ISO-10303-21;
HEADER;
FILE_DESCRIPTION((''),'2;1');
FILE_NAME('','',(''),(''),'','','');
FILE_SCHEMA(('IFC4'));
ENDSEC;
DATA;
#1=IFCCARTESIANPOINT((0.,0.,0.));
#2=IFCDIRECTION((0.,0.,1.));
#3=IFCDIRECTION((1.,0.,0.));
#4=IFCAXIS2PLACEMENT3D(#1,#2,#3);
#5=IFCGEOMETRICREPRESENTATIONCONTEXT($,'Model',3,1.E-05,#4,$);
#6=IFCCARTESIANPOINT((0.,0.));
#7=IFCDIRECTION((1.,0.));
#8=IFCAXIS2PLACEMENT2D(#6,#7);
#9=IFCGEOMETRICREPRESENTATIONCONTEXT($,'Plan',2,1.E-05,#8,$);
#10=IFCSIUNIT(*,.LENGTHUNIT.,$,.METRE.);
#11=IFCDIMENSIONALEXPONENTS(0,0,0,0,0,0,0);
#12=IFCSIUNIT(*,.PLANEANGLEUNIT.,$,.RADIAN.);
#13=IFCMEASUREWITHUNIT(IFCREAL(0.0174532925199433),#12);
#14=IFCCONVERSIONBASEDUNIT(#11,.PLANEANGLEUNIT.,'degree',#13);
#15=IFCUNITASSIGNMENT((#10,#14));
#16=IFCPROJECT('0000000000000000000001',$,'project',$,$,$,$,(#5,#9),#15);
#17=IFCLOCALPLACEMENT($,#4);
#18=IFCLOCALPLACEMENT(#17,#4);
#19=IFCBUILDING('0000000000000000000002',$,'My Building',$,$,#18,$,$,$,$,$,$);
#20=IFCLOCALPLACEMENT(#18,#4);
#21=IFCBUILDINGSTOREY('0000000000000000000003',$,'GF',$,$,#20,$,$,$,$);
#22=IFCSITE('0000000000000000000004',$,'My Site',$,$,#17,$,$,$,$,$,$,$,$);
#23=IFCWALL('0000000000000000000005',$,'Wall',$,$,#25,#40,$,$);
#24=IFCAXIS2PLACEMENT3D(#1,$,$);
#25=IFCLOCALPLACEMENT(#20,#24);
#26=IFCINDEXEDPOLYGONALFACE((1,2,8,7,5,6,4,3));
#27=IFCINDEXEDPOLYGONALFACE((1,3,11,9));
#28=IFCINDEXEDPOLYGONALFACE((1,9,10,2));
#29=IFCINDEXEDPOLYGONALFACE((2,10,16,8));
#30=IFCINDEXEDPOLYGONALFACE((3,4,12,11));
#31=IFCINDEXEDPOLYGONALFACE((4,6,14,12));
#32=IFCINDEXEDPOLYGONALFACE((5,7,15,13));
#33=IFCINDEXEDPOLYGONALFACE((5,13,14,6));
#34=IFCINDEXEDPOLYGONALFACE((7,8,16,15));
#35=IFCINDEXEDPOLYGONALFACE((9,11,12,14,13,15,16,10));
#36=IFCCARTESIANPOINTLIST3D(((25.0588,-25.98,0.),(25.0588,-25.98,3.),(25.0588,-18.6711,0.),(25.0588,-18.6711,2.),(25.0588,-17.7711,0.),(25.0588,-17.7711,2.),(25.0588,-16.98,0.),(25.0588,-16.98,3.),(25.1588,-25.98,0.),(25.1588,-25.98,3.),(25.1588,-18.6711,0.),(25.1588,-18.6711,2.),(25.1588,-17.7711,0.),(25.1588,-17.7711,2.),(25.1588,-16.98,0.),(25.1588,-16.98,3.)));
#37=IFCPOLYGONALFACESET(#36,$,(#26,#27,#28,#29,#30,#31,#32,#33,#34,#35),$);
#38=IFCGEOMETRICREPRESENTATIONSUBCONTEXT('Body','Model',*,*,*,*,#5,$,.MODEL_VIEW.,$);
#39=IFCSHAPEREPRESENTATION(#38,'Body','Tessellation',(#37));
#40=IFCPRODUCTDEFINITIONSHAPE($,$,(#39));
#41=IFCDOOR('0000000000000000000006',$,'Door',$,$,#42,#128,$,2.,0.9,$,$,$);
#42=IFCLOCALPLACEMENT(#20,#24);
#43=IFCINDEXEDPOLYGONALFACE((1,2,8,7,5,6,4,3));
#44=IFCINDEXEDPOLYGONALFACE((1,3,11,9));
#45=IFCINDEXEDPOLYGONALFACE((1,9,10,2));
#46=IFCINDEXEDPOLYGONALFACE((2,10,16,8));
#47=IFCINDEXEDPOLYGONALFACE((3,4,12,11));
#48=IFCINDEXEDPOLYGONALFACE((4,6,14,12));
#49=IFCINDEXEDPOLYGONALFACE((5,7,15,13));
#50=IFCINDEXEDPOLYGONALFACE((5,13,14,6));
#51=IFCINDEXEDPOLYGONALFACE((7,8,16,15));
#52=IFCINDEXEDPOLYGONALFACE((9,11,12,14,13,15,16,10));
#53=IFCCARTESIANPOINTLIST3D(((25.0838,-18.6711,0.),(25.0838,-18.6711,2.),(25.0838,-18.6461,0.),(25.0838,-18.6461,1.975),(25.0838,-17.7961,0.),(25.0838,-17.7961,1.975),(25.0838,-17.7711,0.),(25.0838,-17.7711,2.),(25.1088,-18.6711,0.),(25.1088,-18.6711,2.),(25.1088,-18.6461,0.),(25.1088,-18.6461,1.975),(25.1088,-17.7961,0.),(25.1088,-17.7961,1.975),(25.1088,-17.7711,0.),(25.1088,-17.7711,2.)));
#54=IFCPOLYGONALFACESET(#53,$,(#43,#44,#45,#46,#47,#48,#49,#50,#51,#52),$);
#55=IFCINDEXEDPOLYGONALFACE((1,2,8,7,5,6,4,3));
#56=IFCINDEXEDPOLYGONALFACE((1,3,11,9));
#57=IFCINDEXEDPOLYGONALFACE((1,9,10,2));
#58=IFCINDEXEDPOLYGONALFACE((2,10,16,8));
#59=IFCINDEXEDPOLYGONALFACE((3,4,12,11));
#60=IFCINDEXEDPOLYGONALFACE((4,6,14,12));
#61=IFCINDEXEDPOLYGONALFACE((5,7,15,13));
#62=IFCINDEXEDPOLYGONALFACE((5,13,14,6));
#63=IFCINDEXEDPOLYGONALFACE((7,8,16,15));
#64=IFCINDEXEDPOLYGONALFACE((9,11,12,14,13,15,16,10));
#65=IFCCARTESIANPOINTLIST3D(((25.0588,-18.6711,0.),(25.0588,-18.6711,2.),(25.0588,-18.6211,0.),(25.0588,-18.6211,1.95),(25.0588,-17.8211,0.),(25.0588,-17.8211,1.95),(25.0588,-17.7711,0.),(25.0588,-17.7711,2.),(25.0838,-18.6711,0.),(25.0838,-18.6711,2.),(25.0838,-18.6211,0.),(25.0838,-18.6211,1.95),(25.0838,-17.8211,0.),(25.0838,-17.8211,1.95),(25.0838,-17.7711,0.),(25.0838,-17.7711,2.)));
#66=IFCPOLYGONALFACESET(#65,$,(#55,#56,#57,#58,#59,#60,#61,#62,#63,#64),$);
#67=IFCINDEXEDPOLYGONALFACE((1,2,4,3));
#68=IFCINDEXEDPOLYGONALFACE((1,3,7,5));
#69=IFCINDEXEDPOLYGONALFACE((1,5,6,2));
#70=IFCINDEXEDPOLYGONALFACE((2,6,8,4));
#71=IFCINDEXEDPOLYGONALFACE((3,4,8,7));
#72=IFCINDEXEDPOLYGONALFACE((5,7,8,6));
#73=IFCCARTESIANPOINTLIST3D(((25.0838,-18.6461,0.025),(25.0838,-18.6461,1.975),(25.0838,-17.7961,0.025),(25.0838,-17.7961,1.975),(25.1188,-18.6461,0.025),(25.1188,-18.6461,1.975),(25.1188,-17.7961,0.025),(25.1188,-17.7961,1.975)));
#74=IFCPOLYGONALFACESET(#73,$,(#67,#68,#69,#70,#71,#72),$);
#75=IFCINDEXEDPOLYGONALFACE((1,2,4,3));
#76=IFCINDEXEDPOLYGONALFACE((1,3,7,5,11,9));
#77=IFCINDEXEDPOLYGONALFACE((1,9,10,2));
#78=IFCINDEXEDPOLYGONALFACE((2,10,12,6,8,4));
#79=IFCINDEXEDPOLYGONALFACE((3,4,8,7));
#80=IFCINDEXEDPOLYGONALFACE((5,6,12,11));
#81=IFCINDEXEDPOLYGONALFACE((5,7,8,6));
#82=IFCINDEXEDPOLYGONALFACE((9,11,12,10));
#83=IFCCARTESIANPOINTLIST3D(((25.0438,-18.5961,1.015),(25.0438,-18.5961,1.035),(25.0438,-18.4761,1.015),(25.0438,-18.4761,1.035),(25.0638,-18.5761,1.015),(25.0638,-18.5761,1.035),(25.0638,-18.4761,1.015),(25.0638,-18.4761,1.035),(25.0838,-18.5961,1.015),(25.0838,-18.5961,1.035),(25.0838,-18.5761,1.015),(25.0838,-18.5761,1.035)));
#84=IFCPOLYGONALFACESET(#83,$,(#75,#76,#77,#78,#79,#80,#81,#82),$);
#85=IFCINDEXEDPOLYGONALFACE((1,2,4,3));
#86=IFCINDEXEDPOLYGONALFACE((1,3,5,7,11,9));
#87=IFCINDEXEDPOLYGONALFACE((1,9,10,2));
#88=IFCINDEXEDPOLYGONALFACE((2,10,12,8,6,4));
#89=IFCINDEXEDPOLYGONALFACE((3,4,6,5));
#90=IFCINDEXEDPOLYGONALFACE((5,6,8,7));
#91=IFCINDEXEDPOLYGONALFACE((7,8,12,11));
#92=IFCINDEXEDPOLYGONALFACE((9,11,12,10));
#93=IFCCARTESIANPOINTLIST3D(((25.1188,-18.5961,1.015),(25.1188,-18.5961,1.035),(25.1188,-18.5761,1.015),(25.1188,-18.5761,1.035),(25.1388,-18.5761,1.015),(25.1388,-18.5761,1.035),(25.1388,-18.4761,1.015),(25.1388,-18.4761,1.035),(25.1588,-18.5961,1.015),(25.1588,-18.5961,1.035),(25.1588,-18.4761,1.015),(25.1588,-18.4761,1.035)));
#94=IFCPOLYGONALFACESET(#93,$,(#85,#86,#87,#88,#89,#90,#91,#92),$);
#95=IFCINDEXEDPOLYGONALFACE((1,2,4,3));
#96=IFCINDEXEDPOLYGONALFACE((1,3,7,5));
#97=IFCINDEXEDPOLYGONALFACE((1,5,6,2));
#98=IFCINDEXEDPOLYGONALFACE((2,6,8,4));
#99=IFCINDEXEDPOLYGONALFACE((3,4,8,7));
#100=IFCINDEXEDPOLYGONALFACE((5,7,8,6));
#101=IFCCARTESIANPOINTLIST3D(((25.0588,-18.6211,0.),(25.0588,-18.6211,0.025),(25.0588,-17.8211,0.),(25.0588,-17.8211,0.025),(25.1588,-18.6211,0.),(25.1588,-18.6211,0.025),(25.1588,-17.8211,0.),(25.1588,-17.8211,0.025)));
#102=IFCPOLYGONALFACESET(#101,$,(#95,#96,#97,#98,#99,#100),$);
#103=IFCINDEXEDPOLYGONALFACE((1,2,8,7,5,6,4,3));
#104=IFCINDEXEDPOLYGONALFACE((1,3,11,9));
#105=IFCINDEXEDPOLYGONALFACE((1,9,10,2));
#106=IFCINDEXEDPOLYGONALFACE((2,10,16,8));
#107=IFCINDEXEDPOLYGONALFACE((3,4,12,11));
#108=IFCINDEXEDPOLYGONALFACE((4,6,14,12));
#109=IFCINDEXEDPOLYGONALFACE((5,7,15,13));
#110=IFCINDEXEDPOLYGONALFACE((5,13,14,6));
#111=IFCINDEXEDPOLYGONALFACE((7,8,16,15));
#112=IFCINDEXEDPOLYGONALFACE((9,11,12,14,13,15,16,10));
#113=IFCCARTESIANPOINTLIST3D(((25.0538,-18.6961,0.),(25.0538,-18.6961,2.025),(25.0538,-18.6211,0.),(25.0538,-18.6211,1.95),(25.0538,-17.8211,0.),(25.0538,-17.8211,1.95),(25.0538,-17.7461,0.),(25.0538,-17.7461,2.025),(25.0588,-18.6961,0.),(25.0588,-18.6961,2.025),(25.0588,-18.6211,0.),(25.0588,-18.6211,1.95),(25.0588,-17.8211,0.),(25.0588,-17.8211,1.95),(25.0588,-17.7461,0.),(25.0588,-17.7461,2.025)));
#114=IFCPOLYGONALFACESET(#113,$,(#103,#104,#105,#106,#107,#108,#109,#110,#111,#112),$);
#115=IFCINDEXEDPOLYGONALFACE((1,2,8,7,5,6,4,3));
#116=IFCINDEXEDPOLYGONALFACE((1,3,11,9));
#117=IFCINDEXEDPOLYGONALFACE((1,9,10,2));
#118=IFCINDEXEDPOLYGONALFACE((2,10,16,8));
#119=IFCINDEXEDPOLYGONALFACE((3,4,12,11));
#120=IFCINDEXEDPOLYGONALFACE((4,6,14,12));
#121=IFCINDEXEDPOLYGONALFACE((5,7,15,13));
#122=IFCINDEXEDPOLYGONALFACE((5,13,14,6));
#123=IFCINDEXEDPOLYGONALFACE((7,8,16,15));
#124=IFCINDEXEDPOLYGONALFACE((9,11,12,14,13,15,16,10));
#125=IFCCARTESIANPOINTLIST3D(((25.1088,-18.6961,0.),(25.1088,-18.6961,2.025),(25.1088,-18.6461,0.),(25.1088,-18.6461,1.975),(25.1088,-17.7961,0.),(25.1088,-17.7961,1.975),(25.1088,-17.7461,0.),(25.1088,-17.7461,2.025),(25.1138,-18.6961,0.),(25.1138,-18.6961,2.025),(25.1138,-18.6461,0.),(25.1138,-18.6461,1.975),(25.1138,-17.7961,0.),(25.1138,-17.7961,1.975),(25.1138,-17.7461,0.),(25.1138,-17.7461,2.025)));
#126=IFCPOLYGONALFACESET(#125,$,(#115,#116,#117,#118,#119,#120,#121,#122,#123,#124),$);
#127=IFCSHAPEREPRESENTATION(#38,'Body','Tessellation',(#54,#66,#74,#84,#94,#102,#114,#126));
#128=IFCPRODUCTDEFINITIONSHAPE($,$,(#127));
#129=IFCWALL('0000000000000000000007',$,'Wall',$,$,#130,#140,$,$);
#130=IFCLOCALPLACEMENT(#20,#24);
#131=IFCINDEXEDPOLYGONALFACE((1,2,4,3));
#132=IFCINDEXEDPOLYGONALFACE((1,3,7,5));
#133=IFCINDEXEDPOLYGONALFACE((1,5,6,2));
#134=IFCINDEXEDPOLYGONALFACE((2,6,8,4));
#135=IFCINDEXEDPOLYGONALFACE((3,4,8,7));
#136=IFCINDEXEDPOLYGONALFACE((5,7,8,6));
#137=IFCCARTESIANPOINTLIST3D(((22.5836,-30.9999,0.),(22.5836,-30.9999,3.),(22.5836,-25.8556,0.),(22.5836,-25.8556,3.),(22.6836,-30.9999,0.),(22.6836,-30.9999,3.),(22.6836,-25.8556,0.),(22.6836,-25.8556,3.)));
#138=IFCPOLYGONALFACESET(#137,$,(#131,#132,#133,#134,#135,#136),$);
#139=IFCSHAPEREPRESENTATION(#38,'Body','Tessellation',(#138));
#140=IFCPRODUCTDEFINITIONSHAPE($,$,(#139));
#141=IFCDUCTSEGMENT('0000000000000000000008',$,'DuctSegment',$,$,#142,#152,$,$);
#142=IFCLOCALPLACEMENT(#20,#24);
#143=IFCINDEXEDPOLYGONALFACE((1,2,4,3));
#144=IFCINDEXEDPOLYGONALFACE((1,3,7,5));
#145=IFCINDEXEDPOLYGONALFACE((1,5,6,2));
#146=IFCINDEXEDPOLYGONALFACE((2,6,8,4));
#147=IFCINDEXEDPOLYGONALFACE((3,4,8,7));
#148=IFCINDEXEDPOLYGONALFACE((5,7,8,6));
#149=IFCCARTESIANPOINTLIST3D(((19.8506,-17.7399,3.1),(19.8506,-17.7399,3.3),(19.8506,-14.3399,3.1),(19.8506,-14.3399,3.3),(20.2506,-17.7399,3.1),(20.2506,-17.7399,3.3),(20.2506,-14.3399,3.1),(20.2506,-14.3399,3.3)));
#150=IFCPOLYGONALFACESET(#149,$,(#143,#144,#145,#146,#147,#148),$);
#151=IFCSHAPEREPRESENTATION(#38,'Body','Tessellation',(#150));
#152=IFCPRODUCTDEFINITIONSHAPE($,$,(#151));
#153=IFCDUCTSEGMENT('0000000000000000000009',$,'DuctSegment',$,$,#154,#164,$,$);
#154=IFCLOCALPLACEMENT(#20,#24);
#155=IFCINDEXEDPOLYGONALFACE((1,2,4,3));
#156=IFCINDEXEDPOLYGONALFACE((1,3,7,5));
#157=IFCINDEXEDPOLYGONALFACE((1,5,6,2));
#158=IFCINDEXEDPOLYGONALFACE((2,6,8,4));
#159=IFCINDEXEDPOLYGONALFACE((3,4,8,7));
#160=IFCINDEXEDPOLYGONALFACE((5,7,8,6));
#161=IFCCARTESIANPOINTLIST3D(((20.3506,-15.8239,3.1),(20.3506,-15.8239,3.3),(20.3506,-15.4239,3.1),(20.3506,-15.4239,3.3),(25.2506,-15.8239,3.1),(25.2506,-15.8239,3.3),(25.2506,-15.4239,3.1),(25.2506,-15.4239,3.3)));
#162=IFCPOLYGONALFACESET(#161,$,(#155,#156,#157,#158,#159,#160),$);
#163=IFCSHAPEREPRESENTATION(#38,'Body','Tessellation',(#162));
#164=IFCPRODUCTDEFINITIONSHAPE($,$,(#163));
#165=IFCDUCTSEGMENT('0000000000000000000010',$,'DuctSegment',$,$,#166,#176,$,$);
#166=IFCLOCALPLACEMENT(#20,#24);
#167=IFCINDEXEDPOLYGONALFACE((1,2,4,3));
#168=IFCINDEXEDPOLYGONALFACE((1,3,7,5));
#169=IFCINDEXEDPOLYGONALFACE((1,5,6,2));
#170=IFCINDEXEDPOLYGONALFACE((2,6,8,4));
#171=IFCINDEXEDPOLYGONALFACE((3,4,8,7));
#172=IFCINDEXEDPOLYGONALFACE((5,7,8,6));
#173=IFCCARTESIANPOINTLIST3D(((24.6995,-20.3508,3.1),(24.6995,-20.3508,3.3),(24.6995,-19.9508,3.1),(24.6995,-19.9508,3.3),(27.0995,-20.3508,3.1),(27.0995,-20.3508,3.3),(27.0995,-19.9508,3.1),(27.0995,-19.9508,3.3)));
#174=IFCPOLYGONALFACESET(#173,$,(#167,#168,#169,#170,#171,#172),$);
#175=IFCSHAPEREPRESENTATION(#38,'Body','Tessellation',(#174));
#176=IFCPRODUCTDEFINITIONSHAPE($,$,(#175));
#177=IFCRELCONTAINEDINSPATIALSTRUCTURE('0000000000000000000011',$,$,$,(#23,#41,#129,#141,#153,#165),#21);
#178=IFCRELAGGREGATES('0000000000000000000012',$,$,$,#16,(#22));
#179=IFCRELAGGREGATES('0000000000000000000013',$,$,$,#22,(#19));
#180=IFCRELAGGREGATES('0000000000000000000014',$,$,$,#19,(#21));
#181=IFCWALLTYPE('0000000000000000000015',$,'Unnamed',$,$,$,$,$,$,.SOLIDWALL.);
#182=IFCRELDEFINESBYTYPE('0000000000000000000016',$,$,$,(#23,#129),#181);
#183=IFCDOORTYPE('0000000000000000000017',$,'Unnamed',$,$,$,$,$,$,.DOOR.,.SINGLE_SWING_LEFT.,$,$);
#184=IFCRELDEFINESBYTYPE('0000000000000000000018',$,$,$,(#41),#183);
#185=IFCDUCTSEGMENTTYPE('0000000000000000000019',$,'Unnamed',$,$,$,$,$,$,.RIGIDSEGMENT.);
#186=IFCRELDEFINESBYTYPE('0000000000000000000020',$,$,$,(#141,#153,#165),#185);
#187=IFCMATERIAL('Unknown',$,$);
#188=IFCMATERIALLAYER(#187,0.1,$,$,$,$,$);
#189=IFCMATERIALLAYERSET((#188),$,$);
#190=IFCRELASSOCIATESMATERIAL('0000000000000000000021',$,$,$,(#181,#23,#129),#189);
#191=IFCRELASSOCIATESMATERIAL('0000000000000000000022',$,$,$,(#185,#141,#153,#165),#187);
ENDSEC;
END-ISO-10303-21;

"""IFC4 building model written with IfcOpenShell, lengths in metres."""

from ifc_helpers import new_model, entity, si_unit, converted_unit, frame, origin_with_axes, origin_2d_with_axis, place, context, subcontext, project, spatial, line, indexed_curve, rectangle, outline, extrude, shape, source, transform, mapped, material, layer, layer_set, layer_usage, material_profile, profile_set, profile_usage, type_object, type_shapes, element, fill, save


model = new_model("IFC4")

# Units and contexts
model_context = context("Model", 3, precision=1e-05, world=origin_with_axes())
plan_context = context("Plan", 2, precision=1e-05, world=origin_2d_with_axis())
body_context_1 = subcontext(model_context, "Body", "Model", "MODEL_VIEW")
body_context_2 = subcontext(plan_context, "Body", "Plan", "PLAN_VIEW")
ifc_project = project(units=[si_unit("LENGTHUNIT", "METRE"), converted_unit("PLANEANGLEUNIT", "degree", entity("IfcReal", 0.0174532925199433), si_unit("PLANEANGLEUNIT", "RADIAN"), dimensions=[0, 0, 0, 0, 0, 0, 0])], contexts=[model_context, plan_context])

# Site, building, storey
site_placement = place(None, origin_with_axes())
site = spatial("IfcSite", under=ifc_project, at=site_placement, Name="My Site")
building_placement = place(site_placement, origin_with_axes())
building = spatial("IfcBuilding", under=site, at=building_placement, Name="My Building")
storey_placement = place(building_placement, origin_with_axes())
storey = spatial("IfcBuildingStorey", under=building, at=storey_placement, Name="GF")

# Shared definitions
ifc_material = material(Name="Unknown")
ifc_layer = layer(ifc_material, 0.1)
ifc_layer_set = layer_set([ifc_layer])
wall_type = type_object("IfcWallType", Name="Unnamed", PredefinedType="SOLIDWALL", material=ifc_layer_set)

# Shared definitions
shared_shape_1 = source(origin_with_axes(), body_context_1, "Body", "SweptSolid", [
    extrude(outline(indexed_curve([(0.0, 0.0), (0.9, 0.0), (0.9, 2.0), (0.0, 2.0)], segments=[line(1, 2, 3, 4, 1)])), frame((0.0, -0.6, 0.0), z_axis=(0.0, -1.0, 0.0), x_axis=(1.0, 0.0, 0.0)), (0.0, 0.0, -1.0), 1.2),
])
door_type = type_object("IfcDoorType", Name="Unnamed", OperationType="SINGLE_SWING_LEFT", PredefinedType="DOOR")
shared_shape_2 = source(origin_with_axes(), body_context_1, "Body", "SweptSolid", [
    extrude(outline(indexed_curve([(0.0, 0.0), (0.0, 2.0), (0.9, 2.0), (0.9, 0.0), (0.875, 0.0), (0.875, 1.975), (0.025, 1.975), (0.025, 0.0)], segments=[line(1, 2, 3, 4, 5, 6, 7, 8, 1)])), frame((0.0, 0.025, 0.0), z_axis=(0.0, -1.0, 0.0), x_axis=(1.0, 0.0, 0.0)), (0.0, 0.0, -1.0), 0.025),
    extrude(outline(indexed_curve([(0.0, 0.0), (0.0, 2.0), (0.9, 2.0), (0.9, 0.0), (0.85, 0.0), (0.85, 1.95), (0.05, 1.95), (0.05, 0.0)], segments=[line(1, 2, 3, 4, 5, 6, 7, 8, 1)])), frame((0.0, 0.0, 0.0), z_axis=(0.0, -1.0, 0.0), x_axis=(1.0, 0.0, 0.0)), (0.0, 0.0, -1.0), 0.025),
    extrude(outline(indexed_curve([(0.0, 0.0), (0.85, 0.0), (0.85, 0.035), (0.0, 0.035)], segments=[line(1, 2, 3, 4, 1)])), frame((0.025, 0.025, 0.025), z_axis=(0.0, 0.0, 1.0), x_axis=(1.0, 0.0, 0.0)), (0.0, 0.0, 1.0), 1.95),
    extrude(outline(indexed_curve([(0.0, 0.0), (0.0, -0.04), (-0.12, -0.04), (-0.12, -0.02), (-0.02, -0.02), (-0.02, 0.0)], segments=[line(1, 2, 3, 4, 5, 6, 1)])), frame((0.825, 0.025, 1.015), z_axis=(0.0, 0.0, 1.0), x_axis=(1.0, 0.0, 0.0)), (0.0, 0.0, 1.0), 0.02),
    extrude(outline(indexed_curve([(0.0, 0.0), (0.0, 0.04), (-0.12, 0.04), (-0.12, 0.02), (-0.02, 0.02), (-0.02, 0.0)], segments=[line(1, 2, 3, 4, 5, 6, 1)])), frame((0.825, 0.06, 1.015), z_axis=(0.0, 0.0, 1.0), x_axis=(1.0, 0.0, 0.0)), (0.0, 0.0, 1.0), 0.02),
    extrude(outline(indexed_curve([(0.0, 0.0), (0.8, 0.0), (0.8, 0.1), (0.0, 0.1)], segments=[line(1, 2, 3, 4, 1)])), frame((0.05, 0.0, 0.0), z_axis=(0.0, 0.0, 1.0), x_axis=(1.0, 0.0, 0.0)), (0.0, 0.0, 1.0), 0.025),
    extrude(outline(indexed_curve([(0.0, 0.0), (0.0, 2.025), (0.95, 2.025), (0.95, 0.0), (0.875, 0.0), (0.875, 1.95), (0.075, 1.95), (0.075, 0.0)], segments=[line(1, 2, 3, 4, 5, 6, 7, 8, 1)])), frame((-0.025, -0.005, 0.0), z_axis=(0.0, -1.0, 0.0), x_axis=(1.0, 0.0, 0.0)), (0.0, 0.0, -1.0), 0.005),
    extrude(outline(indexed_curve([(0.0, 0.0), (0.0, 2.025), (0.95, 2.025), (0.95, 0.0), (0.9, 0.0), (0.9, 1.975), (0.05, 1.975), (0.05, 0.0)], segments=[line(1, 2, 3, 4, 5, 6, 7, 8, 1)])), frame((-0.025, 0.05, 0.0), z_axis=(0.0, -1.0, 0.0), x_axis=(1.0, 0.0, 0.0)), (0.0, 0.0, -1.0), 0.005),
])
shared_shape_3 = source(origin_with_axes(), body_context_2, "Body", "Curve2D", [
    entity("IfcIndexedPolyCurve", entity("IfcCartesianPointList2D", [[0.0, 0.0], [0.0, 0.05], [0.025, 0.05], [0.025, 0.025], [0.05, 0.025], [0.05, 0.0]]), [entity("IfcLineIndex", [1, 2, 3, 4, 5, 6, 1])]),
    entity("IfcIndexedPolyCurve", entity("IfcCartesianPointList2D", [[0.9, 0.0], [0.9, 0.05], [0.875, 0.05], [0.875, 0.025], [0.85, 0.025], [0.85, 0.0]]), [entity("IfcLineIndex", [1, 2, 3, 4, 5, 6, 1])]),
    entity("IfcTrimmedCurve", entity("IfcEllipse", entity("IfcAxis2Placement2D", entity("IfcCartesianPoint", [0.06, 0.05]), entity("IfcDirection", [1.0, 0.0])), 0.815, 0.85), [entity("IfcCartesianPoint", [0.875, 0.05])], [entity("IfcCartesianPoint", [0.06, 0.9])], True, "CARTESIAN"),
    entity("IfcIndexedPolyCurve", entity("IfcCartesianPointList2D", [[0.025, 0.05], [0.06, 0.05], [0.06, 0.9], [0.025, 0.9]]), [entity("IfcLineIndex", [1, 2, 3, 4, 1])]),
])
type_shapes(door_type, [shared_shape_2, shared_shape_3])

# Wall, opening, door
ifc_layer_usage_1 = layer_usage(ifc_layer_set, "AXIS2", "POSITIVE", 0.0)
wall_1_placement = place(storey_placement, frame((25.0588, -16.98, 0.0), z_axis=(0.0, 0.0, 1.0), x_axis=(0.0, -1.0, 0.0)))
wall_1 = element("IfcWall", 1, at=wall_1_placement, inside=storey, type_object=wall_type, material=ifc_layer_usage_1, Name="Wall", context=body_context_1, shape_type="SweptSolid", body=[
    extrude(outline(indexed_curve([(0.0, 0.0), (0.0, 0.1), (9.0, 0.1), (9.0, 0.0)], segments=[line(1, 2, 3, 4, 1)])), origin_with_axes(), (0.0, 0.0, 1.0), 3.0),
])
opening_1_placement = place(wall_1_placement, frame((0.7911, 0.0, 0.0), z_axis=(0.0, 0.0, 1.0), x_axis=(1.0, 0.0, 0.0)))
opening_1 = element("IfcOpeningElement", 2, at=opening_1_placement, cuts=wall_1, PredefinedType="OPENING", context=body_context_1, shape_type="MappedRepresentation", body=[
    mapped(shared_shape_1, transform((0.0, 0.0, 0.0), x_axis=(1.0, 0.0, 0.0), y_axis=(0.0, 1.0, 0.0), z_axis=(0.0, 0.0, 1.0), scale=1.0)),
])
door_1_placement = place(opening_1_placement, frame((0.0, 0.0, 0.0), z_axis=(0.0, 0.0, 1.0), x_axis=(1.0, 0.0, 0.0)))
door_1 = element("IfcDoor", 3, at=door_1_placement, inside=storey, type_object=door_type, Name="Door", OverallHeight=2.0, OverallWidth=0.9, shapes=[
    shape(body_context_1, "Body", "MappedRepresentation", [mapped(shared_shape_2, transform((0.0, 0.0, 0.0), x_axis=(1.0, 0.0, 0.0), y_axis=(0.0, 1.0, 0.0), z_axis=(0.0, 0.0, 1.0), scale=1.0))]),
    shape(body_context_2, "Body", "MappedRepresentation", [mapped(shared_shape_3, transform((0.0, 0.0, 0.0), x_axis=(1.0, 0.0, 0.0), y_axis=(0.0, 1.0, 0.0), z_axis=(0.0, 0.0, 1.0), scale=1.0))]),
])
fill(opening_1, door_1)

# Wall
ifc_layer_usage_2 = layer_usage(ifc_layer_set, "AXIS2", "POSITIVE", 0.0)
wall_2_placement = place(storey_placement, frame((22.5836, -25.8556, 0.0), z_axis=(0.0, 0.0, 1.0), x_axis=(0.0, -1.0, 0.0)))
element("IfcWall", 4, at=wall_2_placement, inside=storey, type_object=wall_type, material=ifc_layer_usage_2, Name="Wall", context=body_context_1, shape_type="SweptSolid", body=[
    extrude(outline(indexed_curve([(0.0, 0.0), (0.0, 0.1), (5.1443, 0.1), (5.1443, 0.0)], segments=[line(1, 2, 3, 4, 1)])), origin_with_axes(), (0.0, 0.0, 1.0), 3.0),
])

# Duct segments
ifc_material_profile_1 = material_profile(ifc_material, rectangle(XDim=0.4, YDim=0.2))
ifc_profile_set_1 = profile_set([ifc_material_profile_1])
ifc_profile_usage_1 = profile_usage(ifc_profile_set_1, cardinal=5)
duct_segment_type = type_object("IfcDuctSegmentType", Name="Unnamed", PredefinedType="RIGIDSEGMENT", material=ifc_profile_set_1)
duct_segment_1_placement = place(storey_placement, frame((20.0506, -17.7399, 3.2), z_axis=(0.0, 1.0, -0.000003), x_axis=(-1.0, 0.0, 0.0)))
element("IfcDuctSegment", 5, at=duct_segment_1_placement, inside=storey, type_object=duct_segment_type, material=ifc_profile_usage_1, Name="DuctSegment", context=body_context_1, shape_type="SweptSolid", body=[
    extrude(rectangle(XDim=0.4, YDim=0.2), origin_with_axes(), (0.0, 0.0, 1.0), 3.4),
])
ifc_profile_usage_2 = profile_usage(ifc_profile_set_1, cardinal=5)
duct_segment_2_placement = place(storey_placement, frame((20.3506, -15.6239, 3.2), z_axis=(1.0, -0.000001, 0.000001), x_axis=(0.000001, 1.0, 0.0)))
element("IfcDuctSegment", 6, at=duct_segment_2_placement, inside=storey, type_object=duct_segment_type, material=ifc_profile_usage_2, Name="DuctSegment", context=body_context_1, shape_type="SweptSolid", body=[
    extrude(rectangle(XDim=0.4, YDim=0.2), origin_with_axes(), (0.0, 0.0, 1.0), 4.9),
])
ifc_profile_usage_3 = profile_usage(ifc_profile_set_1, cardinal=5)
duct_segment_3_placement = place(storey_placement, frame((24.6995, -20.1508, 3.2), z_axis=(1.0, -0.000001, 0.000001), x_axis=(0.000001, 1.0, 0.0)))
element("IfcDuctSegment", 7, at=duct_segment_3_placement, inside=storey, type_object=duct_segment_type, material=ifc_profile_usage_3, Name="DuctSegment", context=body_context_1, shape_type="SweptSolid", body=[
    extrude(rectangle(XDim=0.4, YDim=0.2), origin_with_axes(), (0.0, 0.0, 1.0), 2.4),
])

save(model, "model.ifc")
